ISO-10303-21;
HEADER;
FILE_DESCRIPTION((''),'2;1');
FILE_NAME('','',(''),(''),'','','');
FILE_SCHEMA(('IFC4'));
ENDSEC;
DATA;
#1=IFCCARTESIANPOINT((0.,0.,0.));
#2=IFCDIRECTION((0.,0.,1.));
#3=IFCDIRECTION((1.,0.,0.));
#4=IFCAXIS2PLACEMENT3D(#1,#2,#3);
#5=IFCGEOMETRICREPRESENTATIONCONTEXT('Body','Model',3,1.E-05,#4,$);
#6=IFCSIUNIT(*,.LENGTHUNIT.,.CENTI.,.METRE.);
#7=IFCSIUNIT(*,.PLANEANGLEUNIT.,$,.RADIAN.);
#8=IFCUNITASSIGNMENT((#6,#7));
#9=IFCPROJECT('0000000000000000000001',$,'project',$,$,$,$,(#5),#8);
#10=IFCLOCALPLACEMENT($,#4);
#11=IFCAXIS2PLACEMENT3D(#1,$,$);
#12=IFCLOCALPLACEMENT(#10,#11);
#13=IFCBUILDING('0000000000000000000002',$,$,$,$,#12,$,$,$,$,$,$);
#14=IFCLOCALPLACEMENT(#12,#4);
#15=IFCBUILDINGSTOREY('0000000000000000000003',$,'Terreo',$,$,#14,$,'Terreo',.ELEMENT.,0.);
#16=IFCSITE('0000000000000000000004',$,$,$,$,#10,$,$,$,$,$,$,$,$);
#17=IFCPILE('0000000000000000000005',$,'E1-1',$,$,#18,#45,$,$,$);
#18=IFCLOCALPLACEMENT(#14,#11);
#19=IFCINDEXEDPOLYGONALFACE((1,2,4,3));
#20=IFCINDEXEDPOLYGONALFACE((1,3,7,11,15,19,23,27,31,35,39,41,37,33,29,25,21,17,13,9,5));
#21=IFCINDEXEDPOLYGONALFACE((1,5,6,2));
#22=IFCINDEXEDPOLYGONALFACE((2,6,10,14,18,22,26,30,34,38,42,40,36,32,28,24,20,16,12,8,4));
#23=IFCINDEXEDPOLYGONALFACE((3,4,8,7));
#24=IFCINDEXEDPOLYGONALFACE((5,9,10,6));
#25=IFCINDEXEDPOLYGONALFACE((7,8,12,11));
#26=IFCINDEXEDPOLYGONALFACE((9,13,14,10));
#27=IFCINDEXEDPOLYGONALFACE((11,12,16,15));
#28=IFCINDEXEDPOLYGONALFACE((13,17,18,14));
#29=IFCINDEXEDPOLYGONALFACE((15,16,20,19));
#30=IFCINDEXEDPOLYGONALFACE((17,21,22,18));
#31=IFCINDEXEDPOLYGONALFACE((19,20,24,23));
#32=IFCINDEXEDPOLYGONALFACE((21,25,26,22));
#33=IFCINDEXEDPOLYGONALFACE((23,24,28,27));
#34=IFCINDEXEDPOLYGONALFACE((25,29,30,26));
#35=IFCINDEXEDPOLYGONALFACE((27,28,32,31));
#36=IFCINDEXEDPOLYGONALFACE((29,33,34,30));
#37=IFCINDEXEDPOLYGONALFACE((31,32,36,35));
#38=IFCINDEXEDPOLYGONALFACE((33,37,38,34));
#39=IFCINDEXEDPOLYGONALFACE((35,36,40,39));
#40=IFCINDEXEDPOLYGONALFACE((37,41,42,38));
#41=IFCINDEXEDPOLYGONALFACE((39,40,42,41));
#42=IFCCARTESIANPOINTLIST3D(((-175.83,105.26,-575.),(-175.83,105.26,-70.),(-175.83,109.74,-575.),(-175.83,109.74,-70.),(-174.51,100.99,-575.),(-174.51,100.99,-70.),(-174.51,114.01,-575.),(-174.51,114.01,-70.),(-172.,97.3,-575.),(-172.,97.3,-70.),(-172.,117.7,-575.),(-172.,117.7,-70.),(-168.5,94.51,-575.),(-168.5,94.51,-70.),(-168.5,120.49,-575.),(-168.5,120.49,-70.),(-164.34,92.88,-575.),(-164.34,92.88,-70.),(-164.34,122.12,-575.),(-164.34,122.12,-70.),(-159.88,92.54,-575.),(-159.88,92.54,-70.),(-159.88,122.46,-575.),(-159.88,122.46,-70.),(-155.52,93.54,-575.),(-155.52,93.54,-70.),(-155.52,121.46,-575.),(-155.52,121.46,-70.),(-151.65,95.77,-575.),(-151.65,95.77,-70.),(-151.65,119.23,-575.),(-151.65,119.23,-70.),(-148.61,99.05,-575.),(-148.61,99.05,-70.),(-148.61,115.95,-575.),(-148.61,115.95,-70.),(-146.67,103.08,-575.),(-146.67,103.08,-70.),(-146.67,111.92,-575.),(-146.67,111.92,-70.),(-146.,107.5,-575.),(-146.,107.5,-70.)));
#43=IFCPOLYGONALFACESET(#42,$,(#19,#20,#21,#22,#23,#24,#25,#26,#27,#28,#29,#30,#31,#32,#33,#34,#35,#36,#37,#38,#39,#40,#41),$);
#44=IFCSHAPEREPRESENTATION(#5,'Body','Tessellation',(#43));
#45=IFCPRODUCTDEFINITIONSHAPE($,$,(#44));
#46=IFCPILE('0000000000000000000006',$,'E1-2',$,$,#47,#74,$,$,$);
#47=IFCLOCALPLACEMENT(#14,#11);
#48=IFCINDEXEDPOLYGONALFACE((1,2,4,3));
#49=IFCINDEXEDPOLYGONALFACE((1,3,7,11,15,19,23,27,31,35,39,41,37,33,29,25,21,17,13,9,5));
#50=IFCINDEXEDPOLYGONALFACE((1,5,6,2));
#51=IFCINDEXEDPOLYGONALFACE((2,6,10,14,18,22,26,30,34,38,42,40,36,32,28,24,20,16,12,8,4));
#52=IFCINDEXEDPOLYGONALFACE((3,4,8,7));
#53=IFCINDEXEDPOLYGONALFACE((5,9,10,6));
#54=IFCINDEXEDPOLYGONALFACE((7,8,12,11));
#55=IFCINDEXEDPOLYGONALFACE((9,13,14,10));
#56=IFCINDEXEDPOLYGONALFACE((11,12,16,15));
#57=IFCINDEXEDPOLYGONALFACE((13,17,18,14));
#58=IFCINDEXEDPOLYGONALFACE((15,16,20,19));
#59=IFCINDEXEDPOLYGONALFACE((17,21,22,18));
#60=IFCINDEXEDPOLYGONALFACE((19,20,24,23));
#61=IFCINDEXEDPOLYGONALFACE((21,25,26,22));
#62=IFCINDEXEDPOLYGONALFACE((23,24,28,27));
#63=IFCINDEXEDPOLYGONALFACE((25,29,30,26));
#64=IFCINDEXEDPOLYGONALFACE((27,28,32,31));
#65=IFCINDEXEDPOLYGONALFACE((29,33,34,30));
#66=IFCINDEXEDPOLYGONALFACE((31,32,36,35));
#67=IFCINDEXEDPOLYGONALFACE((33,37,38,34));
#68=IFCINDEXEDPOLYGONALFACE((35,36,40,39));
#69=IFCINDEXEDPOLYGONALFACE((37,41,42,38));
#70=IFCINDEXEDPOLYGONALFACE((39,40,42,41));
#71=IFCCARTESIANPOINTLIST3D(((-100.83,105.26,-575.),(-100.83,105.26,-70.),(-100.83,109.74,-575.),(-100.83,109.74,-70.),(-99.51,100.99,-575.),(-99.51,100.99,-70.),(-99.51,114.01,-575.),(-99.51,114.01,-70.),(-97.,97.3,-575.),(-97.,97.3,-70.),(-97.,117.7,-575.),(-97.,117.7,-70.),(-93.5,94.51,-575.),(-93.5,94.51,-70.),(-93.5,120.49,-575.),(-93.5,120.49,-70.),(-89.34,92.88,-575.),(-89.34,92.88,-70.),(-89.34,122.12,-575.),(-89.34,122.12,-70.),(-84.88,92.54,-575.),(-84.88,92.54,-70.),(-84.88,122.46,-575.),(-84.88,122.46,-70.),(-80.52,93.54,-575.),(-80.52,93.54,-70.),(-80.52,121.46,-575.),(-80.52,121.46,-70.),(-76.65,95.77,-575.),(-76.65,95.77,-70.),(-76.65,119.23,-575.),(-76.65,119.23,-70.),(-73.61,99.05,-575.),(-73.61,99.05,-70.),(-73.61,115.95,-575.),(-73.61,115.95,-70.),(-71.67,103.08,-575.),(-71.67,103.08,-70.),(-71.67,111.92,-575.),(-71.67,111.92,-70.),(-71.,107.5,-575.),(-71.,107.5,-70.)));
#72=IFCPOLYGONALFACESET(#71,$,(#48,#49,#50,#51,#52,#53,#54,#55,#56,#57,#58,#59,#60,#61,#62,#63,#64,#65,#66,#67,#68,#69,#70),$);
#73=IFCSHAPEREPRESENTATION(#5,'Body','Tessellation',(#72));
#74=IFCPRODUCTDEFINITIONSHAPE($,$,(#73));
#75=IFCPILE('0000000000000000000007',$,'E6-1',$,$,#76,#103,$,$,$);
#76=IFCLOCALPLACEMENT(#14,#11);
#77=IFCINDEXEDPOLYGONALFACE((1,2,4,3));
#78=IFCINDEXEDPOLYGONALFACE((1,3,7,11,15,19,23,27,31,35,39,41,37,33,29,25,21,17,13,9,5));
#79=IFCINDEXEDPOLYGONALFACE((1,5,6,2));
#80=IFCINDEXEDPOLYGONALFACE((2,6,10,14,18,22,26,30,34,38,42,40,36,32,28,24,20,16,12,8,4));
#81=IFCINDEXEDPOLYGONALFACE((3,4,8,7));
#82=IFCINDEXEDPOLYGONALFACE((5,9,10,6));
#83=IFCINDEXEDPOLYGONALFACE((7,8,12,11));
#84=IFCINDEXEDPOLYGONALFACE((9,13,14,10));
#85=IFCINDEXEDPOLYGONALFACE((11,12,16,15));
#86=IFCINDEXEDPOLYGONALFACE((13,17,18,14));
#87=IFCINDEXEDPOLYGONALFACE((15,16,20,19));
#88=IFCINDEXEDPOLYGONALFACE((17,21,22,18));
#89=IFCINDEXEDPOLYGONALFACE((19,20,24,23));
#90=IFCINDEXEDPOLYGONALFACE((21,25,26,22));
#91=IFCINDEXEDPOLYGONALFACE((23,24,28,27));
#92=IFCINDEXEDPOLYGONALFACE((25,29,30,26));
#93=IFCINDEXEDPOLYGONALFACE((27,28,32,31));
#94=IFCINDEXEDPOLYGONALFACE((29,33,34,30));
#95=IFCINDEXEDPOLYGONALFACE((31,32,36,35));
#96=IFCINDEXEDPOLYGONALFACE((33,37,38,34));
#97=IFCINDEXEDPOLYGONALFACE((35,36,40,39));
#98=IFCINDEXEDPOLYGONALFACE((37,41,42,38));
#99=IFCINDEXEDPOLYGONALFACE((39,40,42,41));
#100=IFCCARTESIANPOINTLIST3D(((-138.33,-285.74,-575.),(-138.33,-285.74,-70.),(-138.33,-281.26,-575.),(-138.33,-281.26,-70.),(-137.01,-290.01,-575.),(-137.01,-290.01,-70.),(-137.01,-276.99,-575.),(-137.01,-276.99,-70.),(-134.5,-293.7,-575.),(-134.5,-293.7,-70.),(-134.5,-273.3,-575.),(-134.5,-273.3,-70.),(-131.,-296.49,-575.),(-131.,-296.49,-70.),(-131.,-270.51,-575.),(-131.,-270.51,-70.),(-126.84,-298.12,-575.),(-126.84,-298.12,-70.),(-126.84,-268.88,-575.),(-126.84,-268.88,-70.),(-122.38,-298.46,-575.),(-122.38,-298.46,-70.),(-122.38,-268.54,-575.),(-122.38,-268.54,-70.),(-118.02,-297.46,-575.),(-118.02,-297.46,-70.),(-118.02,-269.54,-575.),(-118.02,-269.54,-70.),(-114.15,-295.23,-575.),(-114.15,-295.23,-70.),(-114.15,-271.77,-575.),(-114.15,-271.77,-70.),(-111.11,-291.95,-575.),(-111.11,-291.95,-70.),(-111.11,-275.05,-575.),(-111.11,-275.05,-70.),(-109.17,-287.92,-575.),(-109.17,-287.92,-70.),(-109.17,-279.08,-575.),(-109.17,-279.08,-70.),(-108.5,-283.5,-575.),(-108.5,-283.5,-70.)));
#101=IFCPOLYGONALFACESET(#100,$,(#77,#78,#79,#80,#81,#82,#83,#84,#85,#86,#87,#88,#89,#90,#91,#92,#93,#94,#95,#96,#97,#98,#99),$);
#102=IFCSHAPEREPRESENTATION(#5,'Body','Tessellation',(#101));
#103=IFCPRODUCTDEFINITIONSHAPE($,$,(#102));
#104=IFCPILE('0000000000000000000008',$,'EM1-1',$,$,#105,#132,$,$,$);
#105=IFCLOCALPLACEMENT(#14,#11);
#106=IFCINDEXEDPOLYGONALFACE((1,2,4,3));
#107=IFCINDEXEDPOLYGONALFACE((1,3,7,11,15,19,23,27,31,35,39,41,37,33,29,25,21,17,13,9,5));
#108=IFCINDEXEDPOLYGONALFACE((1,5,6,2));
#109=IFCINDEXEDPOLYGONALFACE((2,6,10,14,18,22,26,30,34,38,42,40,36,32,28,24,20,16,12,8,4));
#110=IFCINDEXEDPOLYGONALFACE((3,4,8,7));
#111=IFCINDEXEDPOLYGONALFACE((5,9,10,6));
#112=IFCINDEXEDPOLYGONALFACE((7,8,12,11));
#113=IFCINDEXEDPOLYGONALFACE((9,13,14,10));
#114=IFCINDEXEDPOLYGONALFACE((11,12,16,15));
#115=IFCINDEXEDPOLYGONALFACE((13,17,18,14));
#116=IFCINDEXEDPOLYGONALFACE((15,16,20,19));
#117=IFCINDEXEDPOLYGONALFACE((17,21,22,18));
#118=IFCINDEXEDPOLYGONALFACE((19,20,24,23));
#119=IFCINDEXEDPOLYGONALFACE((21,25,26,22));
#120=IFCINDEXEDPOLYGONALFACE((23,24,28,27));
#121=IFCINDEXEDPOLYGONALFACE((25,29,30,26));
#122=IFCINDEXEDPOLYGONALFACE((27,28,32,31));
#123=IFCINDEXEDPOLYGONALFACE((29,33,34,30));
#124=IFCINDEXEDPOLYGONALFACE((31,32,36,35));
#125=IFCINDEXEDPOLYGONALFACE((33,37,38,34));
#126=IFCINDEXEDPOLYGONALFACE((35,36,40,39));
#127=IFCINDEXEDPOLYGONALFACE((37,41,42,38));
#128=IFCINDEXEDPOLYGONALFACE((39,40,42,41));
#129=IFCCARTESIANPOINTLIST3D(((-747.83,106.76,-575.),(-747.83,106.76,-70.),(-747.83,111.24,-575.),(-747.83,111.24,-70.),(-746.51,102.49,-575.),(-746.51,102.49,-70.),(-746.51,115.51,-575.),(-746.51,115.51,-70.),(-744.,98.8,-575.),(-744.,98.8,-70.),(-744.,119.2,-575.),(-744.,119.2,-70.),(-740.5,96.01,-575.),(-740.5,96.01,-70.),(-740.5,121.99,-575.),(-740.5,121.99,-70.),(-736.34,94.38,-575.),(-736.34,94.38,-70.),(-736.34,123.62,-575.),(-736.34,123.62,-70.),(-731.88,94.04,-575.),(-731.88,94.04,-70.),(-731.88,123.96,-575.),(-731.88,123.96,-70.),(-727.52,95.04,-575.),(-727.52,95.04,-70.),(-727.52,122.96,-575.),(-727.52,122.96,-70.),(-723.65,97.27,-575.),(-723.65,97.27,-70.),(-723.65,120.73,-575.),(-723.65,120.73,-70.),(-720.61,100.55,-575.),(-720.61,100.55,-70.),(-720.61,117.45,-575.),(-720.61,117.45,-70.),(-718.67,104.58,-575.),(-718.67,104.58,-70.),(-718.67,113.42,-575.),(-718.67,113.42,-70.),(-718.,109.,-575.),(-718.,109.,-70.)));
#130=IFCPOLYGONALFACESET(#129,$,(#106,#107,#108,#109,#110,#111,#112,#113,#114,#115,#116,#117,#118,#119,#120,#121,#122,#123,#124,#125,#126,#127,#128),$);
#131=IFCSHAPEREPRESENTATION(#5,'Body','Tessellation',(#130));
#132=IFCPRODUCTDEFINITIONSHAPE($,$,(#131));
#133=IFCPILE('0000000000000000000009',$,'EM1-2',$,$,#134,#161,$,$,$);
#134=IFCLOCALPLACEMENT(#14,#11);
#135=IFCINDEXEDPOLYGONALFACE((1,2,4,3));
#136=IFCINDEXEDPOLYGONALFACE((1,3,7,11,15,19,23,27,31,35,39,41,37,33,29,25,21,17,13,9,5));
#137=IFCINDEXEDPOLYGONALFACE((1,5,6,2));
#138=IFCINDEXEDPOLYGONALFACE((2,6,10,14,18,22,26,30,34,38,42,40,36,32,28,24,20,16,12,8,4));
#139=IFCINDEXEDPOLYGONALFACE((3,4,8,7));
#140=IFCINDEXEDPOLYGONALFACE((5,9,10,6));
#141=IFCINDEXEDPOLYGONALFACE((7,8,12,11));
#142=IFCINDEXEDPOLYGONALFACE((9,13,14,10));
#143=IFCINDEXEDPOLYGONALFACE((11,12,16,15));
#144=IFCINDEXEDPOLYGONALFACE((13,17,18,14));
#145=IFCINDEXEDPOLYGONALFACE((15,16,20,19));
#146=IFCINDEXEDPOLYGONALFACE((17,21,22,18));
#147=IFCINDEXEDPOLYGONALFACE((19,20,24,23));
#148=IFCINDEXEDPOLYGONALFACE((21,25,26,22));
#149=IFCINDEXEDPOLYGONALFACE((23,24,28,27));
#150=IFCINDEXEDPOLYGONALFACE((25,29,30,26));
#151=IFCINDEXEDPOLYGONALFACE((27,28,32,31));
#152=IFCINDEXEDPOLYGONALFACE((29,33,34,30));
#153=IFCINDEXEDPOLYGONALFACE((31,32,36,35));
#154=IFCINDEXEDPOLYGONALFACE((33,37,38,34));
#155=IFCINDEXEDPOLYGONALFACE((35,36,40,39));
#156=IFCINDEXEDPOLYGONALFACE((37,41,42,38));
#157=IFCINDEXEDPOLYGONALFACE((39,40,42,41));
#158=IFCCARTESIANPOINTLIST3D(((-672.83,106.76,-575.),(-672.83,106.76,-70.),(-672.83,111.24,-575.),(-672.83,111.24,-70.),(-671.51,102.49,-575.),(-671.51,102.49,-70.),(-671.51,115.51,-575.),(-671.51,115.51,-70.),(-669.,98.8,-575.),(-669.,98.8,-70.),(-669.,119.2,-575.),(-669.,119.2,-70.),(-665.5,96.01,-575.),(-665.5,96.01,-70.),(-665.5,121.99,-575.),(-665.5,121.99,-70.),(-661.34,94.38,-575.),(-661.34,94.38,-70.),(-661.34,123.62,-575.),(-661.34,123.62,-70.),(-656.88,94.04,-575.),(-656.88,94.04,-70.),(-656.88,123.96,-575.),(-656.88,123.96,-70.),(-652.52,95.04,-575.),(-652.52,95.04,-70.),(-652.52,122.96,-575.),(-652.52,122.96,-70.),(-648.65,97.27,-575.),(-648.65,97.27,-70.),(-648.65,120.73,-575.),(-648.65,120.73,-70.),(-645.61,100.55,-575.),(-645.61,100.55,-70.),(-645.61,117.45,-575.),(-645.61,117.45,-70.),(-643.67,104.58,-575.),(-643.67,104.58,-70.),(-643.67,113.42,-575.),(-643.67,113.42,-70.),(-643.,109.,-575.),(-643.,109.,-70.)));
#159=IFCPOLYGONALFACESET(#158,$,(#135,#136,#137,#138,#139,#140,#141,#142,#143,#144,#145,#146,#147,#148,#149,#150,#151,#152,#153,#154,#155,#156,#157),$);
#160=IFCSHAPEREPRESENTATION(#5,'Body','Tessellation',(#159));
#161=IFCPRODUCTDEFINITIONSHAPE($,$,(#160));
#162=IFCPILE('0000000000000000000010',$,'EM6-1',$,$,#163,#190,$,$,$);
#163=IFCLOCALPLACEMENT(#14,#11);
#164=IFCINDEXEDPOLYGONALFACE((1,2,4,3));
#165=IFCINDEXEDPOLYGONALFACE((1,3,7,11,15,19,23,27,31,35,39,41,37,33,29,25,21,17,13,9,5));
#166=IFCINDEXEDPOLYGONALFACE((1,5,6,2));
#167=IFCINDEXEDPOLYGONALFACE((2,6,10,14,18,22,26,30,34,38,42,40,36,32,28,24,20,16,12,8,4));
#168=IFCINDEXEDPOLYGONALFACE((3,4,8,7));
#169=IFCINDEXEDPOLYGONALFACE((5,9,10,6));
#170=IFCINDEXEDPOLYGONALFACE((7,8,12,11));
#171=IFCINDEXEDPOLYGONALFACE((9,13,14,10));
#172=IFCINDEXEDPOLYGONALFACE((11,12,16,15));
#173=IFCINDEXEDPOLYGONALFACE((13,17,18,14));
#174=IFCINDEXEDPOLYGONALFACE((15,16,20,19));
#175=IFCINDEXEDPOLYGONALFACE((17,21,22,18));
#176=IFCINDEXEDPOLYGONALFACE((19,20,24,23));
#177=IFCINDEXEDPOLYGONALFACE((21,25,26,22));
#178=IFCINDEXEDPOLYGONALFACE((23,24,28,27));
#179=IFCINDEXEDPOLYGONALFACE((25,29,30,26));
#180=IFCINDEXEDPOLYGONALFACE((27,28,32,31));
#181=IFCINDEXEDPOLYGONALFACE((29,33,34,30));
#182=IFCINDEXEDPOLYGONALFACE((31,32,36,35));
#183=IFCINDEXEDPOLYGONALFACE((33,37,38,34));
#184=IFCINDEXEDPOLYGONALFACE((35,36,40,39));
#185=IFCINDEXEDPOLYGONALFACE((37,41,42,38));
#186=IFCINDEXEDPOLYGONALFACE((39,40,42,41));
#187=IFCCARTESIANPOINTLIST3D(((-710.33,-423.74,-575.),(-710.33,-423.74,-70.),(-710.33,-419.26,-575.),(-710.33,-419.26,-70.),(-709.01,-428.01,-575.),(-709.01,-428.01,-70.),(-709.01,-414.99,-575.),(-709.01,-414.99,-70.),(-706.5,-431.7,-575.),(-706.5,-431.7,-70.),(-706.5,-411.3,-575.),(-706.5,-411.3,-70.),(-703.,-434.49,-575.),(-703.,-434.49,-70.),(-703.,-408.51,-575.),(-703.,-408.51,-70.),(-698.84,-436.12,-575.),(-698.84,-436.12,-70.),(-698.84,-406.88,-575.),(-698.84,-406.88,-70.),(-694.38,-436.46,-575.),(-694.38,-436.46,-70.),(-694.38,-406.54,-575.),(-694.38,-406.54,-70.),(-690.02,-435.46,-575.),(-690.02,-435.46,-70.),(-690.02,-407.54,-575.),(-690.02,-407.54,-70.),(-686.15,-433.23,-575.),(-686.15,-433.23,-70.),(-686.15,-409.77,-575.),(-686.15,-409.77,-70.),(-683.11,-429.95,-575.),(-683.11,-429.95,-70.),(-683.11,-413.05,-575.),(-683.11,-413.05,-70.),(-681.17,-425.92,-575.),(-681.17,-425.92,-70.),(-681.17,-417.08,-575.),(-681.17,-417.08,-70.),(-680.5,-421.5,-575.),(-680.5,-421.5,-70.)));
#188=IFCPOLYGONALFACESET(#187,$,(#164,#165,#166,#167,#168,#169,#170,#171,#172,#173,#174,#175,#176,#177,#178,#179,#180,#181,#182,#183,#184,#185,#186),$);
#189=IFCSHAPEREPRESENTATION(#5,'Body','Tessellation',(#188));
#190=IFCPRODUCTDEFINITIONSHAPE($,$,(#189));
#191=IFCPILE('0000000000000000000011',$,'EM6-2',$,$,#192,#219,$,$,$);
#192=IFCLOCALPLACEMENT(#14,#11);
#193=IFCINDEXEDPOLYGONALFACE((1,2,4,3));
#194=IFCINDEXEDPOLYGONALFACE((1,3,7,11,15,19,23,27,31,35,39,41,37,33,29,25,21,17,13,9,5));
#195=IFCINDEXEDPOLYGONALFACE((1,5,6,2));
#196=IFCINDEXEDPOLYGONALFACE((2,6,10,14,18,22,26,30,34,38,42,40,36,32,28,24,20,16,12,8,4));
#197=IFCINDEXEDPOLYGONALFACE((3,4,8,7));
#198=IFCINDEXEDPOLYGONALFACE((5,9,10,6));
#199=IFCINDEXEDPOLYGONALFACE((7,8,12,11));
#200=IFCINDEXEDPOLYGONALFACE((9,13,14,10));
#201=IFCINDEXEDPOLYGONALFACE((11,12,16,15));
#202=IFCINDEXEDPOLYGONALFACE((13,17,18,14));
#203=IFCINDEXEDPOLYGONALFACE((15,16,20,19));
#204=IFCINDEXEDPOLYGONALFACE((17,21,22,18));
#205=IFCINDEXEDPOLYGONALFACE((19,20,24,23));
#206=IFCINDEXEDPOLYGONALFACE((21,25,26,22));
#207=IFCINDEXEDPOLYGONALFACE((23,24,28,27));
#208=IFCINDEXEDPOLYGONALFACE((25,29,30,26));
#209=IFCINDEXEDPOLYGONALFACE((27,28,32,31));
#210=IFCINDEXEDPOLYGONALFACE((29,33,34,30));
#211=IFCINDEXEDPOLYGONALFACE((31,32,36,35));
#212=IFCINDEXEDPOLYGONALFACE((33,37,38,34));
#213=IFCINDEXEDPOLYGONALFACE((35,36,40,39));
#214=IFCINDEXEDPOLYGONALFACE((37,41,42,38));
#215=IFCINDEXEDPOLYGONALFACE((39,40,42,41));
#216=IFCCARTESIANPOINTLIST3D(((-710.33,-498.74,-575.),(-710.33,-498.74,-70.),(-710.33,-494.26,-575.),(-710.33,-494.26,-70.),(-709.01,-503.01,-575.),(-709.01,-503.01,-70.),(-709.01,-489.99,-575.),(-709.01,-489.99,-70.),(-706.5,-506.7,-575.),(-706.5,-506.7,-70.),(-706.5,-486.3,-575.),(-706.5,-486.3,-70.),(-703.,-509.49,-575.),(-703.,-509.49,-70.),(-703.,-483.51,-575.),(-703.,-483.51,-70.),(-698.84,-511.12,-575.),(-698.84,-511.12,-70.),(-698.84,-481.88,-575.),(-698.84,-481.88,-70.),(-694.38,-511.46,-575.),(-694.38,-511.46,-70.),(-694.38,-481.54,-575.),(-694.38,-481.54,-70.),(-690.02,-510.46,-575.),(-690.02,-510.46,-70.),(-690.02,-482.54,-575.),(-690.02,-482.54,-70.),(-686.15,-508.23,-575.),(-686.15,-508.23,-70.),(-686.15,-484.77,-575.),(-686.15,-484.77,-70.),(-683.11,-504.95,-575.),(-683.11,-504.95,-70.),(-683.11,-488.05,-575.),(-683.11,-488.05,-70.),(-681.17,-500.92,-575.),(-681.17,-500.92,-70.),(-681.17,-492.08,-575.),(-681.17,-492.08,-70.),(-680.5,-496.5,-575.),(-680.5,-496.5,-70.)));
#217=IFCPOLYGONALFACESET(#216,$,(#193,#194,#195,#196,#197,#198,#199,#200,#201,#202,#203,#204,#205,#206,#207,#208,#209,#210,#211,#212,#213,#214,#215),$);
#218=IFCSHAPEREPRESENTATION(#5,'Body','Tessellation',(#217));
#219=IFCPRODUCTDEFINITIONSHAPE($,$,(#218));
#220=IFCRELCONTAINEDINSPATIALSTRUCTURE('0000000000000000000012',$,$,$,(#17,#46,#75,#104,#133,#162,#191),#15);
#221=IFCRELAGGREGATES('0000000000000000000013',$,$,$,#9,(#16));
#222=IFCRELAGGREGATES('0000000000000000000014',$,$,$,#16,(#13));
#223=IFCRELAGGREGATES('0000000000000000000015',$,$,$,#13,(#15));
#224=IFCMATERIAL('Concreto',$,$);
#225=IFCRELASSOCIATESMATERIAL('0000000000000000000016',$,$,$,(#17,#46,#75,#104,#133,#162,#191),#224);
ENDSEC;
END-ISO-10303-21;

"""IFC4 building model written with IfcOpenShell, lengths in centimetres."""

from ifc_helpers import new_model, si_unit, frame, origin, origin_with_axes, origin_2d_with_axis, place, context, project, spatial, circle, extrude, material, element, save


model = new_model("IFC4")

# Units and contexts
model_context = context("Model", 3, precision=1e-05, world=origin_with_axes(), identifier="Body")
ifc_project = project(units=[si_unit("LENGTHUNIT", "METRE", prefix="CENTI"), si_unit("PLANEANGLEUNIT", "RADIAN")], contexts=[model_context])

# Site, building, storey
site_placement = place(None, origin_with_axes())
site = spatial("IfcSite", under=ifc_project, at=site_placement)
building_placement = place(site_placement, origin())
building = spatial("IfcBuilding", under=site, at=building_placement)
storey_placement = place(building_placement, origin_with_axes())
storey = spatial("IfcBuildingStorey", under=building, at=storey_placement, Name="Terreo", LongName="Terreo", CompositionType="ELEMENT", Elevation=0.0)

# Piles
ifc_material = material(Name="Concreto")
for number, where, z_axis, x_axis, name in (
    (1, (-161.0, 107.5, -70.0), (0.0, 0.0, 1.0), (1.0, 0.0, 0.0), "E1-1"),
    (2, (-86.0, 107.5, -70.0), (0.0, 0.0, 1.0), (1.0, 0.0, 0.0), "E1-2"),
    (3, (-123.5, -283.5, -70.0), (0.0, 0.0, 1.0), (1.0, 0.0, 0.0), "E6-1"),
    (4, (-733.0, 109.0, -70.0), (0.0, 0.0, 1.0), (1.0, 0.0, 0.0), "EM1-1"),
    (5, (-658.0, 109.0, -70.0), (0.0, 0.0, 1.0), (1.0, 0.0, 0.0), "EM1-2"),
    (6, (-695.5, -421.5, -70.0), (0.0, 0.0, 1.0), (1.0, 0.0, 0.0), "EM6-1"),
    (7, (-695.5, -496.5, -70.0), (0.0, 0.0, 1.0), (1.0, 0.0, 0.0), "EM6-2"),
):
    element("IfcPile", number, at=place(storey_placement, frame(where, z_axis=z_axis, x_axis=x_axis)), inside=storey, material=ifc_material, Name=name, context=model_context, shape_type="SweptSolid", body=[
        extrude(circle(Radius=15.0, at=origin_2d_with_axis()), frame((0.0, 0.0, -505.0), z_axis=(0.0, 0.0, 1.0), x_axis=(1.0, 0.0, 0.0)), (0.0, 0.0, 1.0), 505.0),
    ])

save(model, "model.ifc")
